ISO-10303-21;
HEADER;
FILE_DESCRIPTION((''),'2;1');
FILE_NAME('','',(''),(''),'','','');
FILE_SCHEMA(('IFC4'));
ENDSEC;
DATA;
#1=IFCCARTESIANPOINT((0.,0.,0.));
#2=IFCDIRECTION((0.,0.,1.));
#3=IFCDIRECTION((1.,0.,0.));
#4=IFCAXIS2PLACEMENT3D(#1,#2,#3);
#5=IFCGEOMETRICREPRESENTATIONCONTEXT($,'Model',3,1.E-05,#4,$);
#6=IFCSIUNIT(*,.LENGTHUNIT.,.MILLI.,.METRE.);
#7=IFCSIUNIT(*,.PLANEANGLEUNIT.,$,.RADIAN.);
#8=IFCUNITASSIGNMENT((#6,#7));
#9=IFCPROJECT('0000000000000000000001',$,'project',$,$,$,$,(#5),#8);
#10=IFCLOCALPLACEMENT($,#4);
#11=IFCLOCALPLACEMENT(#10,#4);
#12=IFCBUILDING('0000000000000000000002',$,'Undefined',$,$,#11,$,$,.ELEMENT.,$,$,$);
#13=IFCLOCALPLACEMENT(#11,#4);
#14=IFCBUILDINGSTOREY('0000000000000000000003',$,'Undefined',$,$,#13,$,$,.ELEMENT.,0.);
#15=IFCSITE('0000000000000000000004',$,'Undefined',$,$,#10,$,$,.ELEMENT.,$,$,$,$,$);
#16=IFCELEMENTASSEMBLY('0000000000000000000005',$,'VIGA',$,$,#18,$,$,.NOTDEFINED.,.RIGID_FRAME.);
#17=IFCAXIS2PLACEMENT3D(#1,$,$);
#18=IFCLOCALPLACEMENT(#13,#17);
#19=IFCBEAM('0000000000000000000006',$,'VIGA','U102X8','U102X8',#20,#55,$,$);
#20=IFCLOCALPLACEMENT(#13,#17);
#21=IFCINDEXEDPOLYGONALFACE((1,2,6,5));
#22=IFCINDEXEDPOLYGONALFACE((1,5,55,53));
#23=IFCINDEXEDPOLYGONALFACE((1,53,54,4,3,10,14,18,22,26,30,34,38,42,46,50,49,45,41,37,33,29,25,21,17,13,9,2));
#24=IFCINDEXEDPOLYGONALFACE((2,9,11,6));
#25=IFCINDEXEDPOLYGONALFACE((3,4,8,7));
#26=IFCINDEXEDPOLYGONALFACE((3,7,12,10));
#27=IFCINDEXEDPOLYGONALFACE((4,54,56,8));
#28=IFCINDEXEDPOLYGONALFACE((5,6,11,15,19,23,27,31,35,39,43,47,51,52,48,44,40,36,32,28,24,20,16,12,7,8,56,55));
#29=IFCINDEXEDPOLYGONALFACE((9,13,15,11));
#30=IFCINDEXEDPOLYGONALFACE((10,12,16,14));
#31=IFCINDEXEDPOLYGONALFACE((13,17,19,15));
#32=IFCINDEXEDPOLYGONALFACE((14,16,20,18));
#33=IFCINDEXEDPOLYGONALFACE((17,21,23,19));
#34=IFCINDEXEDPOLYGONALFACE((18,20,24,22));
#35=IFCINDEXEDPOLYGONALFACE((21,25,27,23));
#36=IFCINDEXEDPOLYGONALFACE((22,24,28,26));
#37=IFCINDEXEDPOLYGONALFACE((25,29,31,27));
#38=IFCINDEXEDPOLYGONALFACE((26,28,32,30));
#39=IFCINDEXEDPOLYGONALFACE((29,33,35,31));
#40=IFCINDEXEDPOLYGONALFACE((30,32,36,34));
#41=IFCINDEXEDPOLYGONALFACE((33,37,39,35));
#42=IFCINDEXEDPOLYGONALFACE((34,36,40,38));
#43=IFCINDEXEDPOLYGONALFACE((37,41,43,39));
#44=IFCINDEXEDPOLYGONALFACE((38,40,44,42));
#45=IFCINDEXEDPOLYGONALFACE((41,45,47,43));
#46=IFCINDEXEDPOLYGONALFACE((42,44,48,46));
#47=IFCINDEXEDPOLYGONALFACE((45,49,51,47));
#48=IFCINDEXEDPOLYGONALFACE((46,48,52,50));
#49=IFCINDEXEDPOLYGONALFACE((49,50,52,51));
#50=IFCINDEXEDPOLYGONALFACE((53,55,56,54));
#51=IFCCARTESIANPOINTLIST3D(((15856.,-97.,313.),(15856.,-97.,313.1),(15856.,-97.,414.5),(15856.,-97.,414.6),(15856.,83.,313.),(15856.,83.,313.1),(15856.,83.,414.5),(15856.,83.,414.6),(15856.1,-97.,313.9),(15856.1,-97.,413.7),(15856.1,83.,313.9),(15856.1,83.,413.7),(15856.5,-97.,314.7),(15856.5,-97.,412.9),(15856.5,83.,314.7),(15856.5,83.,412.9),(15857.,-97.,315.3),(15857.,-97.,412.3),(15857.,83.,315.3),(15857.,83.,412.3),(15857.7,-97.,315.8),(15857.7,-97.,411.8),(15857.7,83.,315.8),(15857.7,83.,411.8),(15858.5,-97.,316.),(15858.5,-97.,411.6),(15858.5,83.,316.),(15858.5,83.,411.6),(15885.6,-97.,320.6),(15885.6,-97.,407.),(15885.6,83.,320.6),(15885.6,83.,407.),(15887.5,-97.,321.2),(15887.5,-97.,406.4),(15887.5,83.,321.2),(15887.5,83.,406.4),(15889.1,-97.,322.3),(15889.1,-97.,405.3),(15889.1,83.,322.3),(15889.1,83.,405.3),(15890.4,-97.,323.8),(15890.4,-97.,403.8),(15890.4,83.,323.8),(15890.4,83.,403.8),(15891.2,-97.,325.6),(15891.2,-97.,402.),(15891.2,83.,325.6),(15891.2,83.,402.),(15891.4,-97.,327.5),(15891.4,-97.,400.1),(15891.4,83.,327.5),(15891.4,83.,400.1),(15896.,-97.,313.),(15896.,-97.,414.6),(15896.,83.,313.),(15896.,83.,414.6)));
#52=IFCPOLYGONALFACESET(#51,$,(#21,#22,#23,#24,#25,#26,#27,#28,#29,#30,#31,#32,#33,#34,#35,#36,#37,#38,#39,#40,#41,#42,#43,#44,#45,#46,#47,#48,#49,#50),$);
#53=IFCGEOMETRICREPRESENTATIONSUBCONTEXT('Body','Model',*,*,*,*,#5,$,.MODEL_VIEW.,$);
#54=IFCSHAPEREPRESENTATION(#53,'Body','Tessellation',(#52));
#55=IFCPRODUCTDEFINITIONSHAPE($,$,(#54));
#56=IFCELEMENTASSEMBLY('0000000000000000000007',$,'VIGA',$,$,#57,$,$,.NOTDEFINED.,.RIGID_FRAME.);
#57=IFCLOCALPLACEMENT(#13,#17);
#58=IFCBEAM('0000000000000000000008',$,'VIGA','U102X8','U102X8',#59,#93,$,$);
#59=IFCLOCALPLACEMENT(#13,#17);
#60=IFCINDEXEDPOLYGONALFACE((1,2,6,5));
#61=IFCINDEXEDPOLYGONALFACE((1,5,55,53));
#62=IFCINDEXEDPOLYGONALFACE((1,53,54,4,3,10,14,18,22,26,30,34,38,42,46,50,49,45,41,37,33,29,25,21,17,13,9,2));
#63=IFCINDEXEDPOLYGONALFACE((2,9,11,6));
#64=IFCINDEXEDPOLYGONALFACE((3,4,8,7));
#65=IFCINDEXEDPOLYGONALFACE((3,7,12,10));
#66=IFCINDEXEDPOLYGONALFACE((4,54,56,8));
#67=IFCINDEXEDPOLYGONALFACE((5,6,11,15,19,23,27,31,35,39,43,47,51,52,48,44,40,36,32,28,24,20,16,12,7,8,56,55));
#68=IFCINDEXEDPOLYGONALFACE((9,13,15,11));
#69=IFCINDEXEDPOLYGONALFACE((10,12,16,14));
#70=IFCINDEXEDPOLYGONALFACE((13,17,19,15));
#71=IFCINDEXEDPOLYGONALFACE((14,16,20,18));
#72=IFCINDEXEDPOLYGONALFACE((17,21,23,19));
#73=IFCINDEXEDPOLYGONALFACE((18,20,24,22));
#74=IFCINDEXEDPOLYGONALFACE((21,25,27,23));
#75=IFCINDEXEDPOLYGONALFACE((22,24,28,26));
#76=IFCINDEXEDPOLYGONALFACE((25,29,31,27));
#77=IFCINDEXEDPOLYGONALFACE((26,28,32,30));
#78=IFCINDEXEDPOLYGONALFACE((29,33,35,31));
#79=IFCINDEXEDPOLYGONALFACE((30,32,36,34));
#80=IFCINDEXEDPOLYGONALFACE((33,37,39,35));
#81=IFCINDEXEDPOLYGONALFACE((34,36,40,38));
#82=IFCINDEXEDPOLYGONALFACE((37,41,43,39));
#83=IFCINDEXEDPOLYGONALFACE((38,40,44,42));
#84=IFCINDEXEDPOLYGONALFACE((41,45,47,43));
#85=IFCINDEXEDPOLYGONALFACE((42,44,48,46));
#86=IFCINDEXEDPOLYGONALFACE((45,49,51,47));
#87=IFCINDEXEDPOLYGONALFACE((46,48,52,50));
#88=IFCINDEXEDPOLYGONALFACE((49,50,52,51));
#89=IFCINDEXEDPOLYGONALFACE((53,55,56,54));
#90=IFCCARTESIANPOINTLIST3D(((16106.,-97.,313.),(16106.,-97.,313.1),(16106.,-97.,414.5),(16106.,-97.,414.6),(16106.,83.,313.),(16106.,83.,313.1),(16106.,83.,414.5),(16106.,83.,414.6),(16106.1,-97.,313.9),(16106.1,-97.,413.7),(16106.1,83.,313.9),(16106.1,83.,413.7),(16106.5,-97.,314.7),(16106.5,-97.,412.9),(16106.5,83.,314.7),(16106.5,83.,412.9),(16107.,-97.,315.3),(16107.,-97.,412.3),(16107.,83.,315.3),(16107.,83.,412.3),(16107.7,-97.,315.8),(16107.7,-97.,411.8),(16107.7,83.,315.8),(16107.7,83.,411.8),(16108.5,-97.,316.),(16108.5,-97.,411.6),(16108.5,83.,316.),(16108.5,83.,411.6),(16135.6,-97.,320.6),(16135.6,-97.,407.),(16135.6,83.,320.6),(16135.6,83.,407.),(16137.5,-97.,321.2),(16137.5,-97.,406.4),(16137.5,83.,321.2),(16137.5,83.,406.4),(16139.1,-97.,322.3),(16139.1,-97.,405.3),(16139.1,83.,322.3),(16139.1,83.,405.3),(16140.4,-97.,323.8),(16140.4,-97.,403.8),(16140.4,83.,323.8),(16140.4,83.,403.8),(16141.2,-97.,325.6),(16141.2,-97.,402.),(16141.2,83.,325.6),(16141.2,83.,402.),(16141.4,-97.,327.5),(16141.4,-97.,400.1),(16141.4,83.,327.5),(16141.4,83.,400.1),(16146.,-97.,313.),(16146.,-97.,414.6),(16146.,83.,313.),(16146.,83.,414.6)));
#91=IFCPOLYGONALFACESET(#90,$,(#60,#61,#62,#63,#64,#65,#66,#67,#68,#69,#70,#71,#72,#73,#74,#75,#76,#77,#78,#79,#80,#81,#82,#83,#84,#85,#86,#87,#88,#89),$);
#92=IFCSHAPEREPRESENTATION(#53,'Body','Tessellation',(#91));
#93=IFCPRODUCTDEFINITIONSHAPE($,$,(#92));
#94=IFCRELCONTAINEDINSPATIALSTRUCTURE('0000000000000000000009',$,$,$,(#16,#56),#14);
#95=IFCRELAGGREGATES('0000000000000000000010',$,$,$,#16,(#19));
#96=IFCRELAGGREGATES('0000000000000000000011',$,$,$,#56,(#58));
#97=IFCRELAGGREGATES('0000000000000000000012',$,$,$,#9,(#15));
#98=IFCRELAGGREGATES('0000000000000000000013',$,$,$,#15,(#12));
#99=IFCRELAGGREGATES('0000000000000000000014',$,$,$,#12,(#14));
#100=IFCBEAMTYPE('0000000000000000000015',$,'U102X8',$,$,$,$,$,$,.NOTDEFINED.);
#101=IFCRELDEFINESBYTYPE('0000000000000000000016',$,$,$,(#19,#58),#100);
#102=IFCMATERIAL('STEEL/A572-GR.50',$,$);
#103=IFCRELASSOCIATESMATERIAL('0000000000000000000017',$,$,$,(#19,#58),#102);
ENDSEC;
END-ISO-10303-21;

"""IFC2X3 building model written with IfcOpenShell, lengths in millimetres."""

from ifc_helpers import new_model, si_unit, frame, origin_with_axes, origin_2d_with_axis, place, context, subcontext, project, spatial, u_section, extrude, material, type_object, element, aggregate, save


model = new_model("IFC2X3")

# Units and contexts
model_context = context("Model", 3, precision=1e-05, world=origin_with_axes())
body_context = subcontext(model_context, "Body", "Model", "MODEL_VIEW")
ifc_project = project(units=[si_unit("LENGTHUNIT", "METRE", prefix="MILLI"), si_unit("PLANEANGLEUNIT", "RADIAN")], contexts=[model_context])

# Site, building, storey
site_placement = place(None, origin_with_axes())
site = spatial("IfcSite", under=ifc_project, at=site_placement, Name="Undefined", CompositionType="ELEMENT")
building_placement = place(site_placement, origin_with_axes())
building = spatial("IfcBuilding", under=site, at=building_placement, Name="Undefined", CompositionType="ELEMENT")
storey_placement = place(building_placement, origin_with_axes())
storey = spatial("IfcBuildingStorey", under=building, at=storey_placement, Name="Undefined", CompositionType="ELEMENT", Elevation=0.0)

# Element assemblies, beams
ifc_material = material(Name="STEEL/A572-GR.50")
beam_type = type_object("IfcBeamType", Name="U102X8", PredefinedType="NOTDEFINED")
assembly_1_placement = place(storey_placement, origin_with_axes())
assembly_1 = element("IfcElementAssembly", 1, at=assembly_1_placement, inside=storey, Name="VIGA", AssemblyPlace="NOTDEFINED", PredefinedType="RIGID_FRAME")
beam_1_placement = place(assembly_1_placement, frame((15876.0, 83.0, 363.8), z_axis=(0.0, 0.0, 1.0), x_axis=(0.0, -1.0, 0.0)))
beam_1 = element("IfcBeam", 2, at=beam_1_placement, type_object=beam_type, material=ifc_material, Name="VIGA", Description="U102X8", ObjectType="U102X8", context=body_context, shape_type="SweptSolid", body=[
    extrude(u_section(Depth=101.6, FlangeWidth=40.0, WebThickness=4.6, FlangeThickness=6.0, FilletRadius=7.0, EdgeRadius=3.0, FlangeSlope=0.16839, at=origin_2d_with_axis()), frame((180.0, 0.0, 0.0), z_axis=(-1.0, 0.0, 0.0), x_axis=(0.0, -1.0, 0.0)), (0.0, 0.0, 1.0), 180.0),
])
aggregate(assembly_1, [beam_1])
assembly_2_placement = place(storey_placement, origin_with_axes())
assembly_2 = element("IfcElementAssembly", 3, at=assembly_2_placement, inside=storey, Name="VIGA", AssemblyPlace="NOTDEFINED", PredefinedType="RIGID_FRAME")
beam_2_placement = place(assembly_2_placement, frame((16126.0, 83.0, 363.8), z_axis=(0.0, 0.0, 1.0), x_axis=(0.0, -1.0, 0.0)))
beam_2 = element("IfcBeam", 4, at=beam_2_placement, type_object=beam_type, material=ifc_material, Name="VIGA", Description="U102X8", ObjectType="U102X8", context=body_context, shape_type="SweptSolid", body=[
    extrude(u_section(Depth=101.6, FlangeWidth=40.0, WebThickness=4.6, FlangeThickness=6.0, FilletRadius=7.0, EdgeRadius=3.0, FlangeSlope=0.16839, at=origin_2d_with_axis()), frame((180.0, 0.0, 0.0), z_axis=(-1.0, 0.0, 0.0), x_axis=(0.0, -1.0, 0.0)), (0.0, 0.0, 1.0), 180.0),
])
aggregate(assembly_2, [beam_2])

save(model, "model.ifc")
